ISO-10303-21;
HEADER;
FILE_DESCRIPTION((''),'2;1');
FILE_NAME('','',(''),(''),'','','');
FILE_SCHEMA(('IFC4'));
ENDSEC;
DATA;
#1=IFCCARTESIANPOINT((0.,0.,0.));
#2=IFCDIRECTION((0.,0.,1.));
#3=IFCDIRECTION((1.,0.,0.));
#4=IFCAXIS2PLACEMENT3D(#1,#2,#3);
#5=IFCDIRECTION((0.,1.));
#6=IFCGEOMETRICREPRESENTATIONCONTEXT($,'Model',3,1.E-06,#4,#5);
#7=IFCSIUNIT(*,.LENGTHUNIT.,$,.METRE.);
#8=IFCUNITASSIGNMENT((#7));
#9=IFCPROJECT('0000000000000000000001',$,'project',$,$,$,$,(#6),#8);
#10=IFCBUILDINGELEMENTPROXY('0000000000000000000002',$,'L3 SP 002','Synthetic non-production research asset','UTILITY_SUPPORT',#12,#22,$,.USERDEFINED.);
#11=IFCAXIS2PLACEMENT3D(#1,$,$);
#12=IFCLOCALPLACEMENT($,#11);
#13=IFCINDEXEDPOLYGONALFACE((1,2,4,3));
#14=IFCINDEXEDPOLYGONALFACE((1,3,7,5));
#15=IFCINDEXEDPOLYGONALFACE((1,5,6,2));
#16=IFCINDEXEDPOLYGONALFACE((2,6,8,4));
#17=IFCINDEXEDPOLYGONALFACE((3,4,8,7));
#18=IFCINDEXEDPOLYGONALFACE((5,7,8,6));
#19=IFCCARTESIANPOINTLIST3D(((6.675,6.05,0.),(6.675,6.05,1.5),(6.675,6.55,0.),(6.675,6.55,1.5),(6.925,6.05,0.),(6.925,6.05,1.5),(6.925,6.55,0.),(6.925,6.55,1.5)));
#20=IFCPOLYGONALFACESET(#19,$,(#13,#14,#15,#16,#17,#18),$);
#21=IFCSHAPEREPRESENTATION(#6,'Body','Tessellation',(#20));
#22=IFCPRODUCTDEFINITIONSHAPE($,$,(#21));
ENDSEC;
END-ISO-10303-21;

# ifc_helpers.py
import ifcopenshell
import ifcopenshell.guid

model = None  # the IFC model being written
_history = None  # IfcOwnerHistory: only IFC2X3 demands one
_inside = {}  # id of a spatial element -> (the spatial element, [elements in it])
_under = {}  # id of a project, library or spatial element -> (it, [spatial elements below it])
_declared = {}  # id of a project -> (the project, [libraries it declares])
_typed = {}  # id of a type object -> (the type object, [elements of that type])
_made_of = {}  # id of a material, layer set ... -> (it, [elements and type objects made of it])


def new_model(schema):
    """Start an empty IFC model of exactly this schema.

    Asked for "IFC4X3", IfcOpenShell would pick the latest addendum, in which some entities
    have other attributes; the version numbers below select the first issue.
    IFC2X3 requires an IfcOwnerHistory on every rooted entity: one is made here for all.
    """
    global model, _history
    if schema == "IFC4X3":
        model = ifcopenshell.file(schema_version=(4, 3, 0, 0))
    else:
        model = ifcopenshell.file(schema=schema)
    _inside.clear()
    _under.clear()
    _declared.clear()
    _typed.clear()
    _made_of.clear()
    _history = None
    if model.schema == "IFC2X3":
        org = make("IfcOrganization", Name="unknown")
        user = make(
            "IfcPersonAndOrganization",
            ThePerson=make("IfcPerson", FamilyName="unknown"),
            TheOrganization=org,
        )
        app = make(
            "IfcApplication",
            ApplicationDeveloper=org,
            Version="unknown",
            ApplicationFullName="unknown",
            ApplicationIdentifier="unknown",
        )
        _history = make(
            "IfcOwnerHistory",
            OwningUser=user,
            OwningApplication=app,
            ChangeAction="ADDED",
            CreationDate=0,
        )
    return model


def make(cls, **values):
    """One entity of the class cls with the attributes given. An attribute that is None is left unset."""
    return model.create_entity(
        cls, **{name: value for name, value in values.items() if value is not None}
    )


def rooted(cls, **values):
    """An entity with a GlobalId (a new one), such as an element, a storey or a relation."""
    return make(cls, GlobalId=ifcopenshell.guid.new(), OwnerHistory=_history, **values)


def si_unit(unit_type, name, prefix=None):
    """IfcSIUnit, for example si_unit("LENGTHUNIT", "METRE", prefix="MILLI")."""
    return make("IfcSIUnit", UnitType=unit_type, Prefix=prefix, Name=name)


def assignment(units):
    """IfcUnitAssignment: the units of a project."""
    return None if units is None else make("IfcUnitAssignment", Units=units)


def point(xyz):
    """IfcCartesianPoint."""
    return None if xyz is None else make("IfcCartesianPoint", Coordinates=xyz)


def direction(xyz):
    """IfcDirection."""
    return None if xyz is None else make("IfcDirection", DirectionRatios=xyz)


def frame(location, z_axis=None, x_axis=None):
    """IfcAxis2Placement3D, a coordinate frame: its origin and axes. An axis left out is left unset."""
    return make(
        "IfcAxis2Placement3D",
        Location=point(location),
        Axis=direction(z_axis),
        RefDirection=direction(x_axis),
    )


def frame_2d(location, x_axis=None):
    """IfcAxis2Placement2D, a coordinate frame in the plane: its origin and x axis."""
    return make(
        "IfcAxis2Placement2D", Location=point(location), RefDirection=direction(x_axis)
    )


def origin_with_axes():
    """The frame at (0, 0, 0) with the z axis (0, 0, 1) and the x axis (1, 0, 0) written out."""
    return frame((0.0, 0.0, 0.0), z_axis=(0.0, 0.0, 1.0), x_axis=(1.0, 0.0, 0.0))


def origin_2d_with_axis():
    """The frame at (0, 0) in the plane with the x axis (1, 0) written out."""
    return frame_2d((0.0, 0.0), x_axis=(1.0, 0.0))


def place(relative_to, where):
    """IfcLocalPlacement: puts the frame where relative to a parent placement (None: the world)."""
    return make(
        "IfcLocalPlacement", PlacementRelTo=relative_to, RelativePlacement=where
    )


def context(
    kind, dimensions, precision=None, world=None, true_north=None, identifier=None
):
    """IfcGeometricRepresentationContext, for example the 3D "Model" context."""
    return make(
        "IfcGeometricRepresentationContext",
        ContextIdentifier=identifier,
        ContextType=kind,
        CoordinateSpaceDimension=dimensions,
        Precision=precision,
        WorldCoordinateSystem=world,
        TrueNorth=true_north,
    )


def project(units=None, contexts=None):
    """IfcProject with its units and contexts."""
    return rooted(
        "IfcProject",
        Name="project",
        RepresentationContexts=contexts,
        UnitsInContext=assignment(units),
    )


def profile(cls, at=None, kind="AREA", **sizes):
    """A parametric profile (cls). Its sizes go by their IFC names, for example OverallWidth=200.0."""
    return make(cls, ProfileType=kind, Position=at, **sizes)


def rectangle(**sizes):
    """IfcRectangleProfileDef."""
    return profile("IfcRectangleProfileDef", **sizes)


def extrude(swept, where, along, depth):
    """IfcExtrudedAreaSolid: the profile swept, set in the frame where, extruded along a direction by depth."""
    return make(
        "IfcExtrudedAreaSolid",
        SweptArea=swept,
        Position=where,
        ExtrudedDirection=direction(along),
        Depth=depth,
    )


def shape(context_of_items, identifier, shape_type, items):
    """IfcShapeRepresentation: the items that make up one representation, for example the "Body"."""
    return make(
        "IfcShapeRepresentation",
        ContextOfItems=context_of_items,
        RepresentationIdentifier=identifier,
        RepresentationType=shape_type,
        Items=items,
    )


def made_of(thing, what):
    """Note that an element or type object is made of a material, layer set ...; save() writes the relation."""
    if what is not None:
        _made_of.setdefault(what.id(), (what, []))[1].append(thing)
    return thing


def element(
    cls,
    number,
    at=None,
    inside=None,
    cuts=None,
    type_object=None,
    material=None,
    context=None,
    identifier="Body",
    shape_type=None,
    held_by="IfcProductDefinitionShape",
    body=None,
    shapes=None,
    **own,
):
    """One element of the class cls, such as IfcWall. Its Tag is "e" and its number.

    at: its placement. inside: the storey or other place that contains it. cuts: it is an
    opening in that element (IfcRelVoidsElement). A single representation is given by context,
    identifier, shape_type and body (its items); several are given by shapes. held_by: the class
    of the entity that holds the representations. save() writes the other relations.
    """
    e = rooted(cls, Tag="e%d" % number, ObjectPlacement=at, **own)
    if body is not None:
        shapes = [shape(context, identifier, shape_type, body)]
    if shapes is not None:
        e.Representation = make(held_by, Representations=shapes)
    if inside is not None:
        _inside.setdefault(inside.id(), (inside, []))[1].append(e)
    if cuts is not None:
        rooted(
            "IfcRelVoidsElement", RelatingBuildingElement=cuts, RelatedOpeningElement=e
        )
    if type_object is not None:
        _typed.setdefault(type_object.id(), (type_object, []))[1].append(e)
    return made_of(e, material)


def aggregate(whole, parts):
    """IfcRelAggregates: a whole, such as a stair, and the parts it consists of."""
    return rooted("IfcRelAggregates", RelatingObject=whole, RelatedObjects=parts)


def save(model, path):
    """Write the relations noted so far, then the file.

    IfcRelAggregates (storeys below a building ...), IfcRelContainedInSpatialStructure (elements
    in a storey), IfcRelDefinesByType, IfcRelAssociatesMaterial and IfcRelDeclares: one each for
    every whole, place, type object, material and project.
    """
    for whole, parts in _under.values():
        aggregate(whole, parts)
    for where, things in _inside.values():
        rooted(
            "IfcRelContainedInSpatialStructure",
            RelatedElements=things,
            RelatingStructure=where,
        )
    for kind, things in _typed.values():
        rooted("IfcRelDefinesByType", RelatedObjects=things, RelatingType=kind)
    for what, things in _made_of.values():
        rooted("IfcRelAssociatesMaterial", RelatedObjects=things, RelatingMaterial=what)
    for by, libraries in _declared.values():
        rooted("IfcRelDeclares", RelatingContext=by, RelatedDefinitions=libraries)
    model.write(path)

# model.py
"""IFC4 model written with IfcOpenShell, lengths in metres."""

from ifc_helpers import new_model, si_unit, direction, frame, origin_with_axes, origin_2d_with_axis, place, context, project, rectangle, extrude, element, save


model = new_model("IFC4")

# Units and contexts
model_context = context("Model", 3, precision=1e-06, world=origin_with_axes(), true_north=direction((0.0, 1.0)))
ifc_project = project(units=[si_unit("LENGTHUNIT", "METRE")], contexts=[model_context])

# Building element proxy
proxy_placement = place(None, frame((6.8, 6.3, 0.0), z_axis=(0.0, 0.0, 1.0), x_axis=(1.0, 0.0, 0.0)))
element("IfcBuildingElementProxy", 1, at=proxy_placement, Name="L3 SP 002", Description="Synthetic non-production research asset", ObjectType="UTILITY_SUPPORT", PredefinedType="USERDEFINED", context=model_context, shape_type="SweptSolid", body=[
    extrude(rectangle(XDim=0.25, YDim=0.5, at=origin_2d_with_axis()), origin_with_axes(), (0.0, 0.0, 1.0), 1.5),
])

save(model, "model.ifc")
